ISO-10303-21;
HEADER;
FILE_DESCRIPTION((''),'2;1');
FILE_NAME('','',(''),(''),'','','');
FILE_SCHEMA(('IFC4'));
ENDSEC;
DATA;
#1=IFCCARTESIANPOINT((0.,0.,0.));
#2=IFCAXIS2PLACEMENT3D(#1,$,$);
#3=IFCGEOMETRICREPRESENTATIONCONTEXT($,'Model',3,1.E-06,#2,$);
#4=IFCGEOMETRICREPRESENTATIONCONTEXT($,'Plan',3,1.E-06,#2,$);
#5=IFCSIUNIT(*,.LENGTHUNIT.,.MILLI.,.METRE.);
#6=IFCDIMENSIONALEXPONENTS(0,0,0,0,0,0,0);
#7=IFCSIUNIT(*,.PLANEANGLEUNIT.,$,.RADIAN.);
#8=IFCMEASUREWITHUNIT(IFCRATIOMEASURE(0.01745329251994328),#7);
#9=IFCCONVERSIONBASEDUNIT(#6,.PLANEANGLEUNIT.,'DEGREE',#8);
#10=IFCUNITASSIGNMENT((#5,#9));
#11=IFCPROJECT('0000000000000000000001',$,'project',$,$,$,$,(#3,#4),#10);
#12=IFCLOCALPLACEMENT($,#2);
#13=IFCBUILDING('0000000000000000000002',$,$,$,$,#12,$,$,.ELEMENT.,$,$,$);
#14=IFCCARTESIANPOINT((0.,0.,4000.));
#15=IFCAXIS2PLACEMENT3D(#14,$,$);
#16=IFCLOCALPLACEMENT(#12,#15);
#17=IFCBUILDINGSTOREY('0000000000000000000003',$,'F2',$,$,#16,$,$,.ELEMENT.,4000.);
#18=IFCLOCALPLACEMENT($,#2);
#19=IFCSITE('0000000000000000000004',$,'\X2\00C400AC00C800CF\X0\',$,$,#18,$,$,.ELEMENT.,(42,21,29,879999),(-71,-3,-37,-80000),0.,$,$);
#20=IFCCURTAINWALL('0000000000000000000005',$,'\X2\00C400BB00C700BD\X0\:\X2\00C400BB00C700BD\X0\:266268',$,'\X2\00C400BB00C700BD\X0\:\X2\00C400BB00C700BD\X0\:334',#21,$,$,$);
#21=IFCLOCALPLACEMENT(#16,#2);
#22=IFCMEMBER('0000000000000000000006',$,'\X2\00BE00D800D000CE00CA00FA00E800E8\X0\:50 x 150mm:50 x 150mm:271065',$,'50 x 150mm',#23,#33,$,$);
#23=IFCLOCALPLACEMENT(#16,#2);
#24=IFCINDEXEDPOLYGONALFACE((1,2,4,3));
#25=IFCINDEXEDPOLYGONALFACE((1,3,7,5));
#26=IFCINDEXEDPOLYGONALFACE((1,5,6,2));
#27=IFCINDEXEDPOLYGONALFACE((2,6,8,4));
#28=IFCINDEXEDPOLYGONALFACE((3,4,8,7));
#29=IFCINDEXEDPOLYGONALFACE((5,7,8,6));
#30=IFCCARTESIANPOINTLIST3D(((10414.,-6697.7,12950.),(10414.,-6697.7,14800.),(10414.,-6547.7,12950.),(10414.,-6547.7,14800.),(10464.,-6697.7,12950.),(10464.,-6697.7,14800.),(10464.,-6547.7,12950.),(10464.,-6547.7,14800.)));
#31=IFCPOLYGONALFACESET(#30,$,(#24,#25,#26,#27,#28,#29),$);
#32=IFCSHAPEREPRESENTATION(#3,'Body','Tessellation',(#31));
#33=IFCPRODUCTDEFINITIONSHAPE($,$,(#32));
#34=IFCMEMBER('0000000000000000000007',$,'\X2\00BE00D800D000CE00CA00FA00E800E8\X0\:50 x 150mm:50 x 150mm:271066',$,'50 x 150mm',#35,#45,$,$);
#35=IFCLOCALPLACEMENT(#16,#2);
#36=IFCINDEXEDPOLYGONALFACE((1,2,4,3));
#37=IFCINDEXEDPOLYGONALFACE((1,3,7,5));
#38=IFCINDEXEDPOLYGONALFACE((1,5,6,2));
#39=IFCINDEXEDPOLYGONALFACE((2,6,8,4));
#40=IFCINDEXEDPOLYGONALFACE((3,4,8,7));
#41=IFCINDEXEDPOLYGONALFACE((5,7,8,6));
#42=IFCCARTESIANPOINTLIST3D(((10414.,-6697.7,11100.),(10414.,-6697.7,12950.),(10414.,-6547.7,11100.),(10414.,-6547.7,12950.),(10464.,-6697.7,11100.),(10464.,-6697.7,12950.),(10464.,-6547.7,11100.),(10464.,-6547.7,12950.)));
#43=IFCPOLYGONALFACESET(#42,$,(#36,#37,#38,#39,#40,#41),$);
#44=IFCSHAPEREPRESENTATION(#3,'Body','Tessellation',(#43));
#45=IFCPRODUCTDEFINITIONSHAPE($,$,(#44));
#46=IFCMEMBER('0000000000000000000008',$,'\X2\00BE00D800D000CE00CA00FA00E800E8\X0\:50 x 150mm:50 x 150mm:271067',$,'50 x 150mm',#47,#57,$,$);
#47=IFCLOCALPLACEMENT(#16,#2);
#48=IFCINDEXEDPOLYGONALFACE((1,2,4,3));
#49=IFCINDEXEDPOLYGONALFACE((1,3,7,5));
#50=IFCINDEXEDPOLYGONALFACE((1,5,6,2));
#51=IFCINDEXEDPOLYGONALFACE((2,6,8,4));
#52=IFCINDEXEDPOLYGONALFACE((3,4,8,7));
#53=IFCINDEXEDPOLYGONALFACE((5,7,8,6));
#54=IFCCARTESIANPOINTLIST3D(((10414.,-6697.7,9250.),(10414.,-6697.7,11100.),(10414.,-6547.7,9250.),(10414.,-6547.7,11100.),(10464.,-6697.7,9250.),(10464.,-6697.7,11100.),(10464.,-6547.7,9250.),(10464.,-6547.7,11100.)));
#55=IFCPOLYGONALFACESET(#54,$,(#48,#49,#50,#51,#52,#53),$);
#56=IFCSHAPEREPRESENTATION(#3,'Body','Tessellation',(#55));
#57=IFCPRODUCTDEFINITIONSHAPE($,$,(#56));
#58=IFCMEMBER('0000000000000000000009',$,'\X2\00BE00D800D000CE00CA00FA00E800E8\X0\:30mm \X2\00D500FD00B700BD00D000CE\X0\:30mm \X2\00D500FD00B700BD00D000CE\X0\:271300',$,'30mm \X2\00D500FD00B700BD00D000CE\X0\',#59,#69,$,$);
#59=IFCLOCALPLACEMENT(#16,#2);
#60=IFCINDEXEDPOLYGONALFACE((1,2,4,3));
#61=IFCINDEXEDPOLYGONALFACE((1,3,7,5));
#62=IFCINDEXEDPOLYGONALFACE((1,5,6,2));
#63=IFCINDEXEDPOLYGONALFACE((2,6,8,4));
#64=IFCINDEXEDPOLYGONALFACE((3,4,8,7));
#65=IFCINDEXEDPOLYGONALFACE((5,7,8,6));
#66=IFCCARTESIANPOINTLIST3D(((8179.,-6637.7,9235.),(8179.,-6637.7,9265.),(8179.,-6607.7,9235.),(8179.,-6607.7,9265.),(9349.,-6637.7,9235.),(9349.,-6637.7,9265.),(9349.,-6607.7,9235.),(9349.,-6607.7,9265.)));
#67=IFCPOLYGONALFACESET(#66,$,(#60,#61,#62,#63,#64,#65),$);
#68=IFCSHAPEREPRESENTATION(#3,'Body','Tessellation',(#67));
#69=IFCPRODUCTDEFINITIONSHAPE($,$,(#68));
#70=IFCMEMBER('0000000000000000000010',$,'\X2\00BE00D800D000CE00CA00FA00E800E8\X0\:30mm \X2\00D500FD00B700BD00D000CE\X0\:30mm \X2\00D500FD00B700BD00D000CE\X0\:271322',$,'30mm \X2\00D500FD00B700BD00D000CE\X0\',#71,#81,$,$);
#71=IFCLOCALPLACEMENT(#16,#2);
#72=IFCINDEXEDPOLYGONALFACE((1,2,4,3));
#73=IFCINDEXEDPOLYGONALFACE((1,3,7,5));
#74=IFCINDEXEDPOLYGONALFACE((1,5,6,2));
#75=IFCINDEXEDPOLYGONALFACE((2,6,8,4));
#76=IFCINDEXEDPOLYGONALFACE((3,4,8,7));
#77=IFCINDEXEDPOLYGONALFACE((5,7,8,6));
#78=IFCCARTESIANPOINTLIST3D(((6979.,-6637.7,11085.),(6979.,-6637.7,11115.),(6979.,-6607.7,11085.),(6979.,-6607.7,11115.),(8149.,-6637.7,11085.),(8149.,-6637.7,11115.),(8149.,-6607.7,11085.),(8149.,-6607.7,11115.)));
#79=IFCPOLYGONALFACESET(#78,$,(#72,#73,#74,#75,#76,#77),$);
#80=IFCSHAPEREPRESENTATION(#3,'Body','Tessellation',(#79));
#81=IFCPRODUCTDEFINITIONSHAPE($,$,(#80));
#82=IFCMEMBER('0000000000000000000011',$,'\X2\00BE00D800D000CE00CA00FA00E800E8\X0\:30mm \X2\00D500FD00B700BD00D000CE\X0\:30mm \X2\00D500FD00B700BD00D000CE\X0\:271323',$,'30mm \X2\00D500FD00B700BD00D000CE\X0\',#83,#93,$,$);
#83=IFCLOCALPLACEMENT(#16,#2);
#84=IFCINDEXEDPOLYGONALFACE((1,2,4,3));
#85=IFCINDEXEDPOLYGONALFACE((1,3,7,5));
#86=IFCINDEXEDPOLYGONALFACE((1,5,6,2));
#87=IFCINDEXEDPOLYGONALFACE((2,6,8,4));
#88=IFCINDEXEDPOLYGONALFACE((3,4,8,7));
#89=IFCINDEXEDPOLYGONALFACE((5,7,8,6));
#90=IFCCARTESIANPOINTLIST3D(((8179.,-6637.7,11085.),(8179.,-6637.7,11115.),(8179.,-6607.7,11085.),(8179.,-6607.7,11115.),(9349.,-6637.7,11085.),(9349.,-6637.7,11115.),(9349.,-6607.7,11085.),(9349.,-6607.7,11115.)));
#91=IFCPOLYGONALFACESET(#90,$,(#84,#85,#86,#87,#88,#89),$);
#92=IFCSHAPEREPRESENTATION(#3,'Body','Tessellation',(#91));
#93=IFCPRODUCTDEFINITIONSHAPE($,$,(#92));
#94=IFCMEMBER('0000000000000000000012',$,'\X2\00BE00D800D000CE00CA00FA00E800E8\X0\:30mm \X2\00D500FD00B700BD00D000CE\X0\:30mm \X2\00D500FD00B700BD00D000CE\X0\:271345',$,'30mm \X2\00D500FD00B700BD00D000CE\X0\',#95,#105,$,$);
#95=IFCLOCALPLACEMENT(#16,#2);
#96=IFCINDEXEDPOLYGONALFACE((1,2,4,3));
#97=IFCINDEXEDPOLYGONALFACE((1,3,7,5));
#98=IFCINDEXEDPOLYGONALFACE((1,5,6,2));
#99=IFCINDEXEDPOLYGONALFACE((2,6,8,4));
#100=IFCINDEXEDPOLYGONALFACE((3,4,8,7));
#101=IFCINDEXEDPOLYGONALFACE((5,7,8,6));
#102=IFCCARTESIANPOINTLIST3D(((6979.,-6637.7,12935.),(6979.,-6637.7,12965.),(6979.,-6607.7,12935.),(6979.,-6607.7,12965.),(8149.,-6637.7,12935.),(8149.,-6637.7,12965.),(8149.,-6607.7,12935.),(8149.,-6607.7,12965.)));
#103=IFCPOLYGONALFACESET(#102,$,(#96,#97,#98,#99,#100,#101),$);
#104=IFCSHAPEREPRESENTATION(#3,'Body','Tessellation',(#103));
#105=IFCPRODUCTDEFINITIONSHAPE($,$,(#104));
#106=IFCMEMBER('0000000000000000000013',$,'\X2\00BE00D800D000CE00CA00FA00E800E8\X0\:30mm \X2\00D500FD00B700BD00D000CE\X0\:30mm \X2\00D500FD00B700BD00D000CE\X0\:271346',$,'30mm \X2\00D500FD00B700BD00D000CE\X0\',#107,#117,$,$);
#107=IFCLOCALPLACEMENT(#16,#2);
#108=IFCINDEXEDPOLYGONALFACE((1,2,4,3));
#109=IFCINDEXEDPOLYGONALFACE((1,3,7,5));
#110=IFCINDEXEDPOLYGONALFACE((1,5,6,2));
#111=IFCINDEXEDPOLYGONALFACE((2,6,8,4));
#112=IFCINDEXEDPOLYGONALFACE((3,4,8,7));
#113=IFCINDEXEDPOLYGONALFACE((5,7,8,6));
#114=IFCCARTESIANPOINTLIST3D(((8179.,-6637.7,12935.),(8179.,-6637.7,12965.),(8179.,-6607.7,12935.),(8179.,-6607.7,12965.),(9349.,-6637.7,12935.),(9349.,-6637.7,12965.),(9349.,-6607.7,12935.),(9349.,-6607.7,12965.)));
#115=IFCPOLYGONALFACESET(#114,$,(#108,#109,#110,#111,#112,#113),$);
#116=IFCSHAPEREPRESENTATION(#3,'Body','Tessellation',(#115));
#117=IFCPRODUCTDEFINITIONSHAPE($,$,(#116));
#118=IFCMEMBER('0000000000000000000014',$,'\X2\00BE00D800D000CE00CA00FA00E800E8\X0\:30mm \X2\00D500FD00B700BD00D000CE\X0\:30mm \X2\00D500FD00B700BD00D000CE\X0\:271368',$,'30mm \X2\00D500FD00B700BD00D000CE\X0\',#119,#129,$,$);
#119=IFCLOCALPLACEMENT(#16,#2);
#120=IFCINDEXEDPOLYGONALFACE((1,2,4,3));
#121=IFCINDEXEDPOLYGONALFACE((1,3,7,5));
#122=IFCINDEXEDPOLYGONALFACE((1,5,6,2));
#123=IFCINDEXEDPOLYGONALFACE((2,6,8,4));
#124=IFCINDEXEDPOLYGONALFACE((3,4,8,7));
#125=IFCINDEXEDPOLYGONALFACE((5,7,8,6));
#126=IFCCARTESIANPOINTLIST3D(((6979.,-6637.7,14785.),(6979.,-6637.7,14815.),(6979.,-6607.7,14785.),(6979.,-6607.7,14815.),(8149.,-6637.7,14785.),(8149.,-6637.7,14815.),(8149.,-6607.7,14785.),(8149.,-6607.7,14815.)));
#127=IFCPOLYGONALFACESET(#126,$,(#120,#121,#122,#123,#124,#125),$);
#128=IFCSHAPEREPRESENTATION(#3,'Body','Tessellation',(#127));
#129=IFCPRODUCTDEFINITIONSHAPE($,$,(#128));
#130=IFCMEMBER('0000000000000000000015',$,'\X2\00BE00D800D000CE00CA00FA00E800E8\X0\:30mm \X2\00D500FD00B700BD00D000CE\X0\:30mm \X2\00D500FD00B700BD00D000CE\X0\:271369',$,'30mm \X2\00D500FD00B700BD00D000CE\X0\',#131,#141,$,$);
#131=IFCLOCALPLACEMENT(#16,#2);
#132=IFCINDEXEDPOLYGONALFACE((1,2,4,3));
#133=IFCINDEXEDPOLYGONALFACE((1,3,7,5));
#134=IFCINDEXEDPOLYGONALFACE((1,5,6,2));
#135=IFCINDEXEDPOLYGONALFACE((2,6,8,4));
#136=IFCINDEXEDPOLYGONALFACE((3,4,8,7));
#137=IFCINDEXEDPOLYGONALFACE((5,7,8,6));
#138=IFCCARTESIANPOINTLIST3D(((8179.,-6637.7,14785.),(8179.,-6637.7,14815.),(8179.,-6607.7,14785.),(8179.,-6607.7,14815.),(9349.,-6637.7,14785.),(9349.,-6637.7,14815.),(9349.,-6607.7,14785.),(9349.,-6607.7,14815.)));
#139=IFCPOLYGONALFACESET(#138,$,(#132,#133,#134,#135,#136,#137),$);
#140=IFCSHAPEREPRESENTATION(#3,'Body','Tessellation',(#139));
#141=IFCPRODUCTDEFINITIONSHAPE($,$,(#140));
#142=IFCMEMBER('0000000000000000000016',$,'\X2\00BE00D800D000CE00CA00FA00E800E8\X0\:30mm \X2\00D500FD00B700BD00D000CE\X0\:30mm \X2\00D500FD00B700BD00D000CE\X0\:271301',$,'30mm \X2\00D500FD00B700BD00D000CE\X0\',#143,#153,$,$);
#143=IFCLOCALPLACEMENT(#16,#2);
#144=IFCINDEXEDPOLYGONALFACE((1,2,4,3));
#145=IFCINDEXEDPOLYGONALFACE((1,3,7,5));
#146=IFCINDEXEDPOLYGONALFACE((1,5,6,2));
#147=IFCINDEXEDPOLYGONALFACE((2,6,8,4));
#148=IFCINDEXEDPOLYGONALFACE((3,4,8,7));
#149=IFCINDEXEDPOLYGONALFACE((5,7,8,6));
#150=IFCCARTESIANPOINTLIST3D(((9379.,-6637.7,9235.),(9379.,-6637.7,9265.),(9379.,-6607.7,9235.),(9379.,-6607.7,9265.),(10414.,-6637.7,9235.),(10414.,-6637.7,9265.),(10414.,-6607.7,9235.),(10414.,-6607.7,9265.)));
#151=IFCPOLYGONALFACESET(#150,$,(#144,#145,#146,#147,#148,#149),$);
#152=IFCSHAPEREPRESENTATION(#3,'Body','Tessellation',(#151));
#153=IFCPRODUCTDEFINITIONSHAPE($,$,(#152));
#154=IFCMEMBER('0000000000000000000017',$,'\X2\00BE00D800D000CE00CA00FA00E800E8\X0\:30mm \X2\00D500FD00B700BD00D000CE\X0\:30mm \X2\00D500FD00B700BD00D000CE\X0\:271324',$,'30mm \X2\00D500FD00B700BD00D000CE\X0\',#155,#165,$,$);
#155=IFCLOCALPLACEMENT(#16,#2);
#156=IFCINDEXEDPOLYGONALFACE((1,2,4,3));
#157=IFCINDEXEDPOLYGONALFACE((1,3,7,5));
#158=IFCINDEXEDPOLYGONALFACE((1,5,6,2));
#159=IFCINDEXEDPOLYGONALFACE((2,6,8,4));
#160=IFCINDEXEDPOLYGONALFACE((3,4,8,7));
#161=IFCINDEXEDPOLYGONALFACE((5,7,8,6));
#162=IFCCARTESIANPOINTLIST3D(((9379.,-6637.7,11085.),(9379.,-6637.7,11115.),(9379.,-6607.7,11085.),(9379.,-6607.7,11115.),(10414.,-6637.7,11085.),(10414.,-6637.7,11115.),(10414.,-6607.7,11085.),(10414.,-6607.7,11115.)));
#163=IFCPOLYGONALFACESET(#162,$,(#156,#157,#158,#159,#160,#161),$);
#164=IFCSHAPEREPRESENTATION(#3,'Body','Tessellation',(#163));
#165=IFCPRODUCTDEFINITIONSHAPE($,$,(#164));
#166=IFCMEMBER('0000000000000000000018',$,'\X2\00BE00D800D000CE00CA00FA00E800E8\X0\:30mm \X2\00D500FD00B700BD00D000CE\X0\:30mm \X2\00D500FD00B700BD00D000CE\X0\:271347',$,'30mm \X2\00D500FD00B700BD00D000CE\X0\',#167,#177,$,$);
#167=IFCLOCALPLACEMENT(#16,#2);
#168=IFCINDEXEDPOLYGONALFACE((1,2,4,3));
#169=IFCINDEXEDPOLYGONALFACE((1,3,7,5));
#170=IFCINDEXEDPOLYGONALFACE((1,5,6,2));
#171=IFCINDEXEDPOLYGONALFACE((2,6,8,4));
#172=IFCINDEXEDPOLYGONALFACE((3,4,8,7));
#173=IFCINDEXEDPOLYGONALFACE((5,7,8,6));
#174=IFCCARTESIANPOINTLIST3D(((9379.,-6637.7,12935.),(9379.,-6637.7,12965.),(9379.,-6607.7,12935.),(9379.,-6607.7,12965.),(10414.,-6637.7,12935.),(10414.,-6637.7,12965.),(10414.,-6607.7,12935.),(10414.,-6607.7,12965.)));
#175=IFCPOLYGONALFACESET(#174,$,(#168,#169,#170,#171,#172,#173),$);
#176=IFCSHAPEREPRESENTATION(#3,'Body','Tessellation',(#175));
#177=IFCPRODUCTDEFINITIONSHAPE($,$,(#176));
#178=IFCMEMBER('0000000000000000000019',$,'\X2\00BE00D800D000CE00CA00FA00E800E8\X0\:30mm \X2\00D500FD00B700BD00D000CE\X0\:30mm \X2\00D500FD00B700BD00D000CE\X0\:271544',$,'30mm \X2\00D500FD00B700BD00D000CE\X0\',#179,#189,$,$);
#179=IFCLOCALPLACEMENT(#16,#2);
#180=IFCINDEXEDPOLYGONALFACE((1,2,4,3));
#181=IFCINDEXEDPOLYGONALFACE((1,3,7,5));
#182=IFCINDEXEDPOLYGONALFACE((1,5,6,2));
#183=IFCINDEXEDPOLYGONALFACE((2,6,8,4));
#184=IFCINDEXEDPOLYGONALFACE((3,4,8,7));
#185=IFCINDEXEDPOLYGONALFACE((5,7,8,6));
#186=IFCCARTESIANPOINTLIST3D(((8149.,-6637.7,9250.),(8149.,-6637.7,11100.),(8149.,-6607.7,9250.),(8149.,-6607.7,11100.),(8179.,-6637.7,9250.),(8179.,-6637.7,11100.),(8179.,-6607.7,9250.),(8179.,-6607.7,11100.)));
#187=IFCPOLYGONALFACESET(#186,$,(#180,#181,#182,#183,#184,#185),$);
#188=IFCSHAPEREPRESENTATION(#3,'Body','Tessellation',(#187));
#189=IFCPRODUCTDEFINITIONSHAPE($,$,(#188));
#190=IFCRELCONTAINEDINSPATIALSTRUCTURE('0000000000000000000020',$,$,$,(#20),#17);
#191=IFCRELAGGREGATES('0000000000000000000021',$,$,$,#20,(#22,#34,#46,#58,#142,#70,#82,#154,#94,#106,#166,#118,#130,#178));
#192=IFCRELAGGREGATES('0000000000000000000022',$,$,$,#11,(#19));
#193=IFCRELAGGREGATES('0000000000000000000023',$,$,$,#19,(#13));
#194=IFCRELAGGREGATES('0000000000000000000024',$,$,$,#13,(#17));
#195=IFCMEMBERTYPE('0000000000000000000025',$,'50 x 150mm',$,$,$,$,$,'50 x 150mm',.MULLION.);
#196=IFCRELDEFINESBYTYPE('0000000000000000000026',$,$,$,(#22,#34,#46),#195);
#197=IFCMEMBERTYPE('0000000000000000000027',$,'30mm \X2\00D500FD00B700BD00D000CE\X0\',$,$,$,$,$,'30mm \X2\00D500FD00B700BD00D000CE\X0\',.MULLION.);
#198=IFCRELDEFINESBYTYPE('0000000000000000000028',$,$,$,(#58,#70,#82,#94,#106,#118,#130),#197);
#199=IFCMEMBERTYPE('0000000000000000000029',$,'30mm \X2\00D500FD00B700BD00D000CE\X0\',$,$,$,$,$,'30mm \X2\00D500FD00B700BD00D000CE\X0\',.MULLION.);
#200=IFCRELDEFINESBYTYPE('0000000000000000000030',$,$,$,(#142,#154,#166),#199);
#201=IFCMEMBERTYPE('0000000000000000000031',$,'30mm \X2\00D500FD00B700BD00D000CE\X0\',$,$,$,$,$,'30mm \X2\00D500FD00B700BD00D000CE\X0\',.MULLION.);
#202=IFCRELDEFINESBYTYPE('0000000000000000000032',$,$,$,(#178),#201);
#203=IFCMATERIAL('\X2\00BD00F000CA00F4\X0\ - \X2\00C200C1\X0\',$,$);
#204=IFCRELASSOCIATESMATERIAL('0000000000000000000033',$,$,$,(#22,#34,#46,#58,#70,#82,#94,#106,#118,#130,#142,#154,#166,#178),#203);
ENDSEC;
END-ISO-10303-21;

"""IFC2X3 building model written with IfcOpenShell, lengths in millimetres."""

from ifc_helpers import new_model, entity, si_unit, converted_unit, frame, origin, origin_2d_with_axis, place, context, project, spatial, rectangle, extrude, source, transform, mapped, material, type_object, type_shapes, element, aggregate, save


model = new_model("IFC2X3")

# Units and contexts
model_context = context("Model", 3, precision=1e-06, world=origin())
plan_context = context("Plan", 3, precision=1e-06, world=origin())
ifc_project = project(units=[si_unit("LENGTHUNIT", "METRE", prefix="MILLI"), converted_unit("PLANEANGLEUNIT", "DEGREE", entity("IfcRatioMeasure", 0.01745329251994328), si_unit("PLANEANGLEUNIT", "RADIAN"), dimensions=[0, 0, 0, 0, 0, 0, 0])], contexts=[model_context, plan_context])

# Site, building, storey
site_placement = place(None, origin())
site = spatial("IfcSite", under=ifc_project, at=site_placement, Name="Ä¬ÈÏ", CompositionType="ELEMENT", RefLatitude=(42, 21, 29, 879999), RefLongitude=(-71, -3, -37, -80000), RefElevation=0.0)
building_placement = place(None, origin())
building = spatial("IfcBuilding", under=site, at=building_placement, CompositionType="ELEMENT")
storey_placement = place(building_placement, frame((0.0, 0.0, 4000.0)))
storey = spatial("IfcBuildingStorey", under=building, at=storey_placement, Name="F2", CompositionType="ELEMENT", Elevation=4000.0)

# Curtain wall, members
curtain_wall_placement = place(storey_placement, origin())
curtain_wall = element("IfcCurtainWall", 1, at=curtain_wall_placement, inside=storey, Name="Ä»Ç½:Ä»Ç½:266268", ObjectType="Ä»Ç½:Ä»Ç½:334")
ifc_material_1 = material(Name="½ðÊô - ÂÁ")
member_type_1 = type_object("IfcMemberType", Name="50 x 150mm", ElementType="50 x 150mm", PredefinedType="MULLION")
shared_shape_1 = source(origin(), model_context, "Body", "SweptSolid", [
    extrude(rectangle(XDim=50.0, YDim=150.0, at=origin_2d_with_axis()), frame((-25.0, 0.0, -1850.0), z_axis=(0.0, 0.0, 1.0), x_axis=(-1.0, 0.0, 0.0)), (0.0, 0.0, 1.0), 1850.0),
])
type_shapes(member_type_1, [shared_shape_1])
placement_1 = place(building_placement, frame((0.0, 0.0, 15100.0)))
member_1_placement = place(placement_1, frame((10464.0, -6622.7, 1850.0), z_axis=(0.0, 0.0, -1.0), x_axis=(1.0, 0.0, 0.0)))
member_1 = element("IfcMember", 2, at=member_1_placement, type_object=member_type_1, material=ifc_material_1, Name="¾ØÐÎÊúèè:50 x 150mm:50 x 150mm:271065", ObjectType="50 x 150mm", context=model_context, shape_type="MappedRepresentation", body=[
    mapped(shared_shape_1, transform((0.0, 0.0, 0.0), scale=1.0)),
])
member_2_placement = place(placement_1, frame((10464.0, -6622.7, 0.0), z_axis=(0.0, 0.0, -1.0), x_axis=(1.0, 0.0, 0.0)))
member_2 = element("IfcMember", 3, at=member_2_placement, type_object=member_type_1, material=ifc_material_1, Name="¾ØÐÎÊúèè:50 x 150mm:50 x 150mm:271066", ObjectType="50 x 150mm", context=model_context, shape_type="MappedRepresentation", body=[
    mapped(shared_shape_1, transform((0.0, 0.0, 0.0), scale=1.0)),
])
placement_2 = place(building_placement, frame((0.0, 0.0, 11400.0)))
member_3_placement = place(placement_2, frame((10464.0, -6622.7, 1850.0), z_axis=(0.0, 0.0, -1.0), x_axis=(1.0, 0.0, 0.0)))
member_3 = element("IfcMember", 4, at=member_3_placement, type_object=member_type_1, material=ifc_material_1, Name="¾ØÐÎÊúèè:50 x 150mm:50 x 150mm:271067", ObjectType="50 x 150mm", context=model_context, shape_type="MappedRepresentation", body=[
    mapped(shared_shape_1, transform((0.0, 0.0, 0.0), scale=1.0)),
])
member_type_2 = type_object("IfcMemberType", Name="30mm Õý·½ÐÎ", ElementType="30mm Õý·½ÐÎ", PredefinedType="MULLION")
shared_shape_2 = source(origin(), model_context, "Body", "SweptSolid", [
    extrude(rectangle(XDim=30.0, YDim=30.0, at=origin_2d_with_axis()), frame((0.0, 0.0, -1170.0), z_axis=(0.0, 0.0, 1.0), x_axis=(-1.0, 0.0, 0.0)), (0.0, 0.0, 1.0), 1170.0),
])
type_shapes(member_type_2, [shared_shape_2])
member_4_placement = place(placement_2, frame((9349.0, -6622.7, 1850.0), z_axis=(1.0, 0.0, 0.0), x_axis=(0.0, 0.0, 1.0)))
member_4 = element("IfcMember", 5, at=member_4_placement, type_object=member_type_2, material=ifc_material_1, Name="¾ØÐÎÊúèè:30mm Õý·½ÐÎ:30mm Õý·½ÐÎ:271300", ObjectType="30mm Õý·½ÐÎ", context=model_context, shape_type="MappedRepresentation", body=[
    mapped(shared_shape_2, transform((0.0, 0.0, 0.0), scale=1.0)),
])
member_5_placement = place(placement_1, frame((8149.0, -6622.7, 0.0), z_axis=(1.0, 0.0, 0.0), x_axis=(0.0, 0.0, 1.0)))
member_5 = element("IfcMember", 6, at=member_5_placement, type_object=member_type_2, material=ifc_material_1, Name="¾ØÐÎÊúèè:30mm Õý·½ÐÎ:30mm Õý·½ÐÎ:271322", ObjectType="30mm Õý·½ÐÎ", context=model_context, shape_type="MappedRepresentation", body=[
    mapped(shared_shape_2, transform((0.0, 0.0, 0.0), scale=1.0)),
])
member_6_placement = place(placement_1, frame((9349.0, -6622.7, 0.0), z_axis=(1.0, 0.0, 0.0), x_axis=(0.0, 0.0, 1.0)))
member_6 = element("IfcMember", 7, at=member_6_placement, type_object=member_type_2, material=ifc_material_1, Name="¾ØÐÎÊúèè:30mm Õý·½ÐÎ:30mm Õý·½ÐÎ:271323", ObjectType="30mm Õý·½ÐÎ", context=model_context, shape_type="MappedRepresentation", body=[
    mapped(shared_shape_2, transform((0.0, 0.0, 0.0), scale=1.0)),
])
member_7_placement = place(placement_1, frame((8149.0, -6622.7, 1850.0), z_axis=(1.0, 0.0, 0.0), x_axis=(0.0, 0.0, 1.0)))
member_7 = element("IfcMember", 8, at=member_7_placement, type_object=member_type_2, material=ifc_material_1, Name="¾ØÐÎÊúèè:30mm Õý·½ÐÎ:30mm Õý·½ÐÎ:271345", ObjectType="30mm Õý·½ÐÎ", context=model_context, shape_type="MappedRepresentation", body=[
    mapped(shared_shape_2, transform((0.0, 0.0, 0.0), scale=1.0)),
])
member_8_placement = place(placement_1, frame((9349.0, -6622.7, 1850.0), z_axis=(1.0, 0.0, 0.0), x_axis=(0.0, 0.0, 1.0)))
member_8 = element("IfcMember", 9, at=member_8_placement, type_object=member_type_2, material=ifc_material_1, Name="¾ØÐÎÊúèè:30mm Õý·½ÐÎ:30mm Õý·½ÐÎ:271346", ObjectType="30mm Õý·½ÐÎ", context=model_context, shape_type="MappedRepresentation", body=[
    mapped(shared_shape_2, transform((0.0, 0.0, 0.0), scale=1.0)),
])
placement_3 = place(building_placement, frame((0.0, 0.0, 18800.0)))
member_9_placement = place(placement_3, frame((8149.0, -6622.7, 0.0), z_axis=(1.0, 0.0, 0.0), x_axis=(0.0, 0.0, 1.0)))
member_9 = element("IfcMember", 10, at=member_9_placement, type_object=member_type_2, material=ifc_material_1, Name="¾ØÐÎÊúèè:30mm Õý·½ÐÎ:30mm Õý·½ÐÎ:271368", ObjectType="30mm Õý·½ÐÎ", context=model_context, shape_type="MappedRepresentation", body=[
    mapped(shared_shape_2, transform((0.0, 0.0, 0.0), scale=1.0)),
])
member_10_placement = place(placement_3, frame((9349.0, -6622.7, 0.0), z_axis=(1.0, 0.0, 0.0), x_axis=(0.0, 0.0, 1.0)))
member_10 = element("IfcMember", 11, at=member_10_placement, type_object=member_type_2, material=ifc_material_1, Name="¾ØÐÎÊúèè:30mm Õý·½ÐÎ:30mm Õý·½ÐÎ:271369", ObjectType="30mm Õý·½ÐÎ", context=model_context, shape_type="MappedRepresentation", body=[
    mapped(shared_shape_2, transform((0.0, 0.0, 0.0), scale=1.0)),
])
member_type_3 = type_object("IfcMemberType", Name="30mm Õý·½ÐÎ", ElementType="30mm Õý·½ÐÎ", PredefinedType="MULLION")
shared_shape_3 = source(origin(), model_context, "Body", "SweptSolid", [
    extrude(rectangle(XDim=30.0, YDim=30.0, at=origin_2d_with_axis()), frame((0.0, 0.0, -1035.0), z_axis=(0.0, 0.0, 1.0), x_axis=(-1.0, 0.0, 0.0)), (0.0, 0.0, 1.0), 1035.0),
])
type_shapes(member_type_3, [shared_shape_3])
member_11_placement = place(placement_2, frame((10414.0, -6622.7, 1850.0), z_axis=(1.0, 0.0, 0.0), x_axis=(0.0, 0.0, 1.0)))
member_11 = element("IfcMember", 12, at=member_11_placement, type_object=member_type_3, material=ifc_material_1, Name="¾ØÐÎÊúèè:30mm Õý·½ÐÎ:30mm Õý·½ÐÎ:271301", ObjectType="30mm Õý·½ÐÎ", context=model_context, shape_type="MappedRepresentation", body=[
    mapped(shared_shape_3, transform((0.0, 0.0, 0.0), scale=1.0)),
])
member_12_placement = place(placement_1, frame((10414.0, -6622.7, 0.0), z_axis=(1.0, 0.0, 0.0), x_axis=(0.0, 0.0, 1.0)))
member_12 = element("IfcMember", 13, at=member_12_placement, type_object=member_type_3, material=ifc_material_1, Name="¾ØÐÎÊúèè:30mm Õý·½ÐÎ:30mm Õý·½ÐÎ:271324", ObjectType="30mm Õý·½ÐÎ", context=model_context, shape_type="MappedRepresentation", body=[
    mapped(shared_shape_3, transform((0.0, 0.0, 0.0), scale=1.0)),
])
member_13_placement = place(placement_1, frame((10414.0, -6622.7, 1850.0), z_axis=(1.0, 0.0, 0.0), x_axis=(0.0, 0.0, 1.0)))
member_13 = element("IfcMember", 14, at=member_13_placement, type_object=member_type_3, material=ifc_material_1, Name="¾ØÐÎÊúèè:30mm Õý·½ÐÎ:30mm Õý·½ÐÎ:271347", ObjectType="30mm Õý·½ÐÎ", context=model_context, shape_type="MappedRepresentation", body=[
    mapped(shared_shape_3, transform((0.0, 0.0, 0.0), scale=1.0)),
])
member_type_4 = type_object("IfcMemberType", Name="30mm Õý·½ÐÎ", ElementType="30mm Õý·½ÐÎ", PredefinedType="MULLION")
shared_shape_4 = source(origin(), model_context, "Body", "SweptSolid", [
    extrude(rectangle(XDim=30.0, YDim=30.0, at=origin_2d_with_axis()), frame((0.0, 0.0, -1850.0), z_axis=(0.0, 0.0, 1.0), x_axis=(-1.0, 0.0, 0.0)), (0.0, 0.0, 1.0), 1850.0),
])
type_shapes(member_type_4, [shared_shape_4])
member_14_placement = place(placement_2, frame((8164.0, -6622.7, 1850.0), z_axis=(0.0, 0.0, -1.0), x_axis=(1.0, 0.0, 0.0)))
member_14 = element("IfcMember", 15, at=member_14_placement, type_object=member_type_4, material=ifc_material_1, Name="¾ØÐÎÊúèè:30mm Õý·½ÐÎ:30mm Õý·½ÐÎ:271544", ObjectType="30mm Õý·½ÐÎ", context=model_context, shape_type="MappedRepresentation", body=[
    mapped(shared_shape_4, transform((0.0, 0.0, 0.0), scale=1.0)),
])
aggregate(curtain_wall, [member_1, member_2, member_3, member_4, member_11, member_5, member_6, member_12, member_7, member_8, member_13, member_9, member_10, member_14])

save(model, "model.ifc")
